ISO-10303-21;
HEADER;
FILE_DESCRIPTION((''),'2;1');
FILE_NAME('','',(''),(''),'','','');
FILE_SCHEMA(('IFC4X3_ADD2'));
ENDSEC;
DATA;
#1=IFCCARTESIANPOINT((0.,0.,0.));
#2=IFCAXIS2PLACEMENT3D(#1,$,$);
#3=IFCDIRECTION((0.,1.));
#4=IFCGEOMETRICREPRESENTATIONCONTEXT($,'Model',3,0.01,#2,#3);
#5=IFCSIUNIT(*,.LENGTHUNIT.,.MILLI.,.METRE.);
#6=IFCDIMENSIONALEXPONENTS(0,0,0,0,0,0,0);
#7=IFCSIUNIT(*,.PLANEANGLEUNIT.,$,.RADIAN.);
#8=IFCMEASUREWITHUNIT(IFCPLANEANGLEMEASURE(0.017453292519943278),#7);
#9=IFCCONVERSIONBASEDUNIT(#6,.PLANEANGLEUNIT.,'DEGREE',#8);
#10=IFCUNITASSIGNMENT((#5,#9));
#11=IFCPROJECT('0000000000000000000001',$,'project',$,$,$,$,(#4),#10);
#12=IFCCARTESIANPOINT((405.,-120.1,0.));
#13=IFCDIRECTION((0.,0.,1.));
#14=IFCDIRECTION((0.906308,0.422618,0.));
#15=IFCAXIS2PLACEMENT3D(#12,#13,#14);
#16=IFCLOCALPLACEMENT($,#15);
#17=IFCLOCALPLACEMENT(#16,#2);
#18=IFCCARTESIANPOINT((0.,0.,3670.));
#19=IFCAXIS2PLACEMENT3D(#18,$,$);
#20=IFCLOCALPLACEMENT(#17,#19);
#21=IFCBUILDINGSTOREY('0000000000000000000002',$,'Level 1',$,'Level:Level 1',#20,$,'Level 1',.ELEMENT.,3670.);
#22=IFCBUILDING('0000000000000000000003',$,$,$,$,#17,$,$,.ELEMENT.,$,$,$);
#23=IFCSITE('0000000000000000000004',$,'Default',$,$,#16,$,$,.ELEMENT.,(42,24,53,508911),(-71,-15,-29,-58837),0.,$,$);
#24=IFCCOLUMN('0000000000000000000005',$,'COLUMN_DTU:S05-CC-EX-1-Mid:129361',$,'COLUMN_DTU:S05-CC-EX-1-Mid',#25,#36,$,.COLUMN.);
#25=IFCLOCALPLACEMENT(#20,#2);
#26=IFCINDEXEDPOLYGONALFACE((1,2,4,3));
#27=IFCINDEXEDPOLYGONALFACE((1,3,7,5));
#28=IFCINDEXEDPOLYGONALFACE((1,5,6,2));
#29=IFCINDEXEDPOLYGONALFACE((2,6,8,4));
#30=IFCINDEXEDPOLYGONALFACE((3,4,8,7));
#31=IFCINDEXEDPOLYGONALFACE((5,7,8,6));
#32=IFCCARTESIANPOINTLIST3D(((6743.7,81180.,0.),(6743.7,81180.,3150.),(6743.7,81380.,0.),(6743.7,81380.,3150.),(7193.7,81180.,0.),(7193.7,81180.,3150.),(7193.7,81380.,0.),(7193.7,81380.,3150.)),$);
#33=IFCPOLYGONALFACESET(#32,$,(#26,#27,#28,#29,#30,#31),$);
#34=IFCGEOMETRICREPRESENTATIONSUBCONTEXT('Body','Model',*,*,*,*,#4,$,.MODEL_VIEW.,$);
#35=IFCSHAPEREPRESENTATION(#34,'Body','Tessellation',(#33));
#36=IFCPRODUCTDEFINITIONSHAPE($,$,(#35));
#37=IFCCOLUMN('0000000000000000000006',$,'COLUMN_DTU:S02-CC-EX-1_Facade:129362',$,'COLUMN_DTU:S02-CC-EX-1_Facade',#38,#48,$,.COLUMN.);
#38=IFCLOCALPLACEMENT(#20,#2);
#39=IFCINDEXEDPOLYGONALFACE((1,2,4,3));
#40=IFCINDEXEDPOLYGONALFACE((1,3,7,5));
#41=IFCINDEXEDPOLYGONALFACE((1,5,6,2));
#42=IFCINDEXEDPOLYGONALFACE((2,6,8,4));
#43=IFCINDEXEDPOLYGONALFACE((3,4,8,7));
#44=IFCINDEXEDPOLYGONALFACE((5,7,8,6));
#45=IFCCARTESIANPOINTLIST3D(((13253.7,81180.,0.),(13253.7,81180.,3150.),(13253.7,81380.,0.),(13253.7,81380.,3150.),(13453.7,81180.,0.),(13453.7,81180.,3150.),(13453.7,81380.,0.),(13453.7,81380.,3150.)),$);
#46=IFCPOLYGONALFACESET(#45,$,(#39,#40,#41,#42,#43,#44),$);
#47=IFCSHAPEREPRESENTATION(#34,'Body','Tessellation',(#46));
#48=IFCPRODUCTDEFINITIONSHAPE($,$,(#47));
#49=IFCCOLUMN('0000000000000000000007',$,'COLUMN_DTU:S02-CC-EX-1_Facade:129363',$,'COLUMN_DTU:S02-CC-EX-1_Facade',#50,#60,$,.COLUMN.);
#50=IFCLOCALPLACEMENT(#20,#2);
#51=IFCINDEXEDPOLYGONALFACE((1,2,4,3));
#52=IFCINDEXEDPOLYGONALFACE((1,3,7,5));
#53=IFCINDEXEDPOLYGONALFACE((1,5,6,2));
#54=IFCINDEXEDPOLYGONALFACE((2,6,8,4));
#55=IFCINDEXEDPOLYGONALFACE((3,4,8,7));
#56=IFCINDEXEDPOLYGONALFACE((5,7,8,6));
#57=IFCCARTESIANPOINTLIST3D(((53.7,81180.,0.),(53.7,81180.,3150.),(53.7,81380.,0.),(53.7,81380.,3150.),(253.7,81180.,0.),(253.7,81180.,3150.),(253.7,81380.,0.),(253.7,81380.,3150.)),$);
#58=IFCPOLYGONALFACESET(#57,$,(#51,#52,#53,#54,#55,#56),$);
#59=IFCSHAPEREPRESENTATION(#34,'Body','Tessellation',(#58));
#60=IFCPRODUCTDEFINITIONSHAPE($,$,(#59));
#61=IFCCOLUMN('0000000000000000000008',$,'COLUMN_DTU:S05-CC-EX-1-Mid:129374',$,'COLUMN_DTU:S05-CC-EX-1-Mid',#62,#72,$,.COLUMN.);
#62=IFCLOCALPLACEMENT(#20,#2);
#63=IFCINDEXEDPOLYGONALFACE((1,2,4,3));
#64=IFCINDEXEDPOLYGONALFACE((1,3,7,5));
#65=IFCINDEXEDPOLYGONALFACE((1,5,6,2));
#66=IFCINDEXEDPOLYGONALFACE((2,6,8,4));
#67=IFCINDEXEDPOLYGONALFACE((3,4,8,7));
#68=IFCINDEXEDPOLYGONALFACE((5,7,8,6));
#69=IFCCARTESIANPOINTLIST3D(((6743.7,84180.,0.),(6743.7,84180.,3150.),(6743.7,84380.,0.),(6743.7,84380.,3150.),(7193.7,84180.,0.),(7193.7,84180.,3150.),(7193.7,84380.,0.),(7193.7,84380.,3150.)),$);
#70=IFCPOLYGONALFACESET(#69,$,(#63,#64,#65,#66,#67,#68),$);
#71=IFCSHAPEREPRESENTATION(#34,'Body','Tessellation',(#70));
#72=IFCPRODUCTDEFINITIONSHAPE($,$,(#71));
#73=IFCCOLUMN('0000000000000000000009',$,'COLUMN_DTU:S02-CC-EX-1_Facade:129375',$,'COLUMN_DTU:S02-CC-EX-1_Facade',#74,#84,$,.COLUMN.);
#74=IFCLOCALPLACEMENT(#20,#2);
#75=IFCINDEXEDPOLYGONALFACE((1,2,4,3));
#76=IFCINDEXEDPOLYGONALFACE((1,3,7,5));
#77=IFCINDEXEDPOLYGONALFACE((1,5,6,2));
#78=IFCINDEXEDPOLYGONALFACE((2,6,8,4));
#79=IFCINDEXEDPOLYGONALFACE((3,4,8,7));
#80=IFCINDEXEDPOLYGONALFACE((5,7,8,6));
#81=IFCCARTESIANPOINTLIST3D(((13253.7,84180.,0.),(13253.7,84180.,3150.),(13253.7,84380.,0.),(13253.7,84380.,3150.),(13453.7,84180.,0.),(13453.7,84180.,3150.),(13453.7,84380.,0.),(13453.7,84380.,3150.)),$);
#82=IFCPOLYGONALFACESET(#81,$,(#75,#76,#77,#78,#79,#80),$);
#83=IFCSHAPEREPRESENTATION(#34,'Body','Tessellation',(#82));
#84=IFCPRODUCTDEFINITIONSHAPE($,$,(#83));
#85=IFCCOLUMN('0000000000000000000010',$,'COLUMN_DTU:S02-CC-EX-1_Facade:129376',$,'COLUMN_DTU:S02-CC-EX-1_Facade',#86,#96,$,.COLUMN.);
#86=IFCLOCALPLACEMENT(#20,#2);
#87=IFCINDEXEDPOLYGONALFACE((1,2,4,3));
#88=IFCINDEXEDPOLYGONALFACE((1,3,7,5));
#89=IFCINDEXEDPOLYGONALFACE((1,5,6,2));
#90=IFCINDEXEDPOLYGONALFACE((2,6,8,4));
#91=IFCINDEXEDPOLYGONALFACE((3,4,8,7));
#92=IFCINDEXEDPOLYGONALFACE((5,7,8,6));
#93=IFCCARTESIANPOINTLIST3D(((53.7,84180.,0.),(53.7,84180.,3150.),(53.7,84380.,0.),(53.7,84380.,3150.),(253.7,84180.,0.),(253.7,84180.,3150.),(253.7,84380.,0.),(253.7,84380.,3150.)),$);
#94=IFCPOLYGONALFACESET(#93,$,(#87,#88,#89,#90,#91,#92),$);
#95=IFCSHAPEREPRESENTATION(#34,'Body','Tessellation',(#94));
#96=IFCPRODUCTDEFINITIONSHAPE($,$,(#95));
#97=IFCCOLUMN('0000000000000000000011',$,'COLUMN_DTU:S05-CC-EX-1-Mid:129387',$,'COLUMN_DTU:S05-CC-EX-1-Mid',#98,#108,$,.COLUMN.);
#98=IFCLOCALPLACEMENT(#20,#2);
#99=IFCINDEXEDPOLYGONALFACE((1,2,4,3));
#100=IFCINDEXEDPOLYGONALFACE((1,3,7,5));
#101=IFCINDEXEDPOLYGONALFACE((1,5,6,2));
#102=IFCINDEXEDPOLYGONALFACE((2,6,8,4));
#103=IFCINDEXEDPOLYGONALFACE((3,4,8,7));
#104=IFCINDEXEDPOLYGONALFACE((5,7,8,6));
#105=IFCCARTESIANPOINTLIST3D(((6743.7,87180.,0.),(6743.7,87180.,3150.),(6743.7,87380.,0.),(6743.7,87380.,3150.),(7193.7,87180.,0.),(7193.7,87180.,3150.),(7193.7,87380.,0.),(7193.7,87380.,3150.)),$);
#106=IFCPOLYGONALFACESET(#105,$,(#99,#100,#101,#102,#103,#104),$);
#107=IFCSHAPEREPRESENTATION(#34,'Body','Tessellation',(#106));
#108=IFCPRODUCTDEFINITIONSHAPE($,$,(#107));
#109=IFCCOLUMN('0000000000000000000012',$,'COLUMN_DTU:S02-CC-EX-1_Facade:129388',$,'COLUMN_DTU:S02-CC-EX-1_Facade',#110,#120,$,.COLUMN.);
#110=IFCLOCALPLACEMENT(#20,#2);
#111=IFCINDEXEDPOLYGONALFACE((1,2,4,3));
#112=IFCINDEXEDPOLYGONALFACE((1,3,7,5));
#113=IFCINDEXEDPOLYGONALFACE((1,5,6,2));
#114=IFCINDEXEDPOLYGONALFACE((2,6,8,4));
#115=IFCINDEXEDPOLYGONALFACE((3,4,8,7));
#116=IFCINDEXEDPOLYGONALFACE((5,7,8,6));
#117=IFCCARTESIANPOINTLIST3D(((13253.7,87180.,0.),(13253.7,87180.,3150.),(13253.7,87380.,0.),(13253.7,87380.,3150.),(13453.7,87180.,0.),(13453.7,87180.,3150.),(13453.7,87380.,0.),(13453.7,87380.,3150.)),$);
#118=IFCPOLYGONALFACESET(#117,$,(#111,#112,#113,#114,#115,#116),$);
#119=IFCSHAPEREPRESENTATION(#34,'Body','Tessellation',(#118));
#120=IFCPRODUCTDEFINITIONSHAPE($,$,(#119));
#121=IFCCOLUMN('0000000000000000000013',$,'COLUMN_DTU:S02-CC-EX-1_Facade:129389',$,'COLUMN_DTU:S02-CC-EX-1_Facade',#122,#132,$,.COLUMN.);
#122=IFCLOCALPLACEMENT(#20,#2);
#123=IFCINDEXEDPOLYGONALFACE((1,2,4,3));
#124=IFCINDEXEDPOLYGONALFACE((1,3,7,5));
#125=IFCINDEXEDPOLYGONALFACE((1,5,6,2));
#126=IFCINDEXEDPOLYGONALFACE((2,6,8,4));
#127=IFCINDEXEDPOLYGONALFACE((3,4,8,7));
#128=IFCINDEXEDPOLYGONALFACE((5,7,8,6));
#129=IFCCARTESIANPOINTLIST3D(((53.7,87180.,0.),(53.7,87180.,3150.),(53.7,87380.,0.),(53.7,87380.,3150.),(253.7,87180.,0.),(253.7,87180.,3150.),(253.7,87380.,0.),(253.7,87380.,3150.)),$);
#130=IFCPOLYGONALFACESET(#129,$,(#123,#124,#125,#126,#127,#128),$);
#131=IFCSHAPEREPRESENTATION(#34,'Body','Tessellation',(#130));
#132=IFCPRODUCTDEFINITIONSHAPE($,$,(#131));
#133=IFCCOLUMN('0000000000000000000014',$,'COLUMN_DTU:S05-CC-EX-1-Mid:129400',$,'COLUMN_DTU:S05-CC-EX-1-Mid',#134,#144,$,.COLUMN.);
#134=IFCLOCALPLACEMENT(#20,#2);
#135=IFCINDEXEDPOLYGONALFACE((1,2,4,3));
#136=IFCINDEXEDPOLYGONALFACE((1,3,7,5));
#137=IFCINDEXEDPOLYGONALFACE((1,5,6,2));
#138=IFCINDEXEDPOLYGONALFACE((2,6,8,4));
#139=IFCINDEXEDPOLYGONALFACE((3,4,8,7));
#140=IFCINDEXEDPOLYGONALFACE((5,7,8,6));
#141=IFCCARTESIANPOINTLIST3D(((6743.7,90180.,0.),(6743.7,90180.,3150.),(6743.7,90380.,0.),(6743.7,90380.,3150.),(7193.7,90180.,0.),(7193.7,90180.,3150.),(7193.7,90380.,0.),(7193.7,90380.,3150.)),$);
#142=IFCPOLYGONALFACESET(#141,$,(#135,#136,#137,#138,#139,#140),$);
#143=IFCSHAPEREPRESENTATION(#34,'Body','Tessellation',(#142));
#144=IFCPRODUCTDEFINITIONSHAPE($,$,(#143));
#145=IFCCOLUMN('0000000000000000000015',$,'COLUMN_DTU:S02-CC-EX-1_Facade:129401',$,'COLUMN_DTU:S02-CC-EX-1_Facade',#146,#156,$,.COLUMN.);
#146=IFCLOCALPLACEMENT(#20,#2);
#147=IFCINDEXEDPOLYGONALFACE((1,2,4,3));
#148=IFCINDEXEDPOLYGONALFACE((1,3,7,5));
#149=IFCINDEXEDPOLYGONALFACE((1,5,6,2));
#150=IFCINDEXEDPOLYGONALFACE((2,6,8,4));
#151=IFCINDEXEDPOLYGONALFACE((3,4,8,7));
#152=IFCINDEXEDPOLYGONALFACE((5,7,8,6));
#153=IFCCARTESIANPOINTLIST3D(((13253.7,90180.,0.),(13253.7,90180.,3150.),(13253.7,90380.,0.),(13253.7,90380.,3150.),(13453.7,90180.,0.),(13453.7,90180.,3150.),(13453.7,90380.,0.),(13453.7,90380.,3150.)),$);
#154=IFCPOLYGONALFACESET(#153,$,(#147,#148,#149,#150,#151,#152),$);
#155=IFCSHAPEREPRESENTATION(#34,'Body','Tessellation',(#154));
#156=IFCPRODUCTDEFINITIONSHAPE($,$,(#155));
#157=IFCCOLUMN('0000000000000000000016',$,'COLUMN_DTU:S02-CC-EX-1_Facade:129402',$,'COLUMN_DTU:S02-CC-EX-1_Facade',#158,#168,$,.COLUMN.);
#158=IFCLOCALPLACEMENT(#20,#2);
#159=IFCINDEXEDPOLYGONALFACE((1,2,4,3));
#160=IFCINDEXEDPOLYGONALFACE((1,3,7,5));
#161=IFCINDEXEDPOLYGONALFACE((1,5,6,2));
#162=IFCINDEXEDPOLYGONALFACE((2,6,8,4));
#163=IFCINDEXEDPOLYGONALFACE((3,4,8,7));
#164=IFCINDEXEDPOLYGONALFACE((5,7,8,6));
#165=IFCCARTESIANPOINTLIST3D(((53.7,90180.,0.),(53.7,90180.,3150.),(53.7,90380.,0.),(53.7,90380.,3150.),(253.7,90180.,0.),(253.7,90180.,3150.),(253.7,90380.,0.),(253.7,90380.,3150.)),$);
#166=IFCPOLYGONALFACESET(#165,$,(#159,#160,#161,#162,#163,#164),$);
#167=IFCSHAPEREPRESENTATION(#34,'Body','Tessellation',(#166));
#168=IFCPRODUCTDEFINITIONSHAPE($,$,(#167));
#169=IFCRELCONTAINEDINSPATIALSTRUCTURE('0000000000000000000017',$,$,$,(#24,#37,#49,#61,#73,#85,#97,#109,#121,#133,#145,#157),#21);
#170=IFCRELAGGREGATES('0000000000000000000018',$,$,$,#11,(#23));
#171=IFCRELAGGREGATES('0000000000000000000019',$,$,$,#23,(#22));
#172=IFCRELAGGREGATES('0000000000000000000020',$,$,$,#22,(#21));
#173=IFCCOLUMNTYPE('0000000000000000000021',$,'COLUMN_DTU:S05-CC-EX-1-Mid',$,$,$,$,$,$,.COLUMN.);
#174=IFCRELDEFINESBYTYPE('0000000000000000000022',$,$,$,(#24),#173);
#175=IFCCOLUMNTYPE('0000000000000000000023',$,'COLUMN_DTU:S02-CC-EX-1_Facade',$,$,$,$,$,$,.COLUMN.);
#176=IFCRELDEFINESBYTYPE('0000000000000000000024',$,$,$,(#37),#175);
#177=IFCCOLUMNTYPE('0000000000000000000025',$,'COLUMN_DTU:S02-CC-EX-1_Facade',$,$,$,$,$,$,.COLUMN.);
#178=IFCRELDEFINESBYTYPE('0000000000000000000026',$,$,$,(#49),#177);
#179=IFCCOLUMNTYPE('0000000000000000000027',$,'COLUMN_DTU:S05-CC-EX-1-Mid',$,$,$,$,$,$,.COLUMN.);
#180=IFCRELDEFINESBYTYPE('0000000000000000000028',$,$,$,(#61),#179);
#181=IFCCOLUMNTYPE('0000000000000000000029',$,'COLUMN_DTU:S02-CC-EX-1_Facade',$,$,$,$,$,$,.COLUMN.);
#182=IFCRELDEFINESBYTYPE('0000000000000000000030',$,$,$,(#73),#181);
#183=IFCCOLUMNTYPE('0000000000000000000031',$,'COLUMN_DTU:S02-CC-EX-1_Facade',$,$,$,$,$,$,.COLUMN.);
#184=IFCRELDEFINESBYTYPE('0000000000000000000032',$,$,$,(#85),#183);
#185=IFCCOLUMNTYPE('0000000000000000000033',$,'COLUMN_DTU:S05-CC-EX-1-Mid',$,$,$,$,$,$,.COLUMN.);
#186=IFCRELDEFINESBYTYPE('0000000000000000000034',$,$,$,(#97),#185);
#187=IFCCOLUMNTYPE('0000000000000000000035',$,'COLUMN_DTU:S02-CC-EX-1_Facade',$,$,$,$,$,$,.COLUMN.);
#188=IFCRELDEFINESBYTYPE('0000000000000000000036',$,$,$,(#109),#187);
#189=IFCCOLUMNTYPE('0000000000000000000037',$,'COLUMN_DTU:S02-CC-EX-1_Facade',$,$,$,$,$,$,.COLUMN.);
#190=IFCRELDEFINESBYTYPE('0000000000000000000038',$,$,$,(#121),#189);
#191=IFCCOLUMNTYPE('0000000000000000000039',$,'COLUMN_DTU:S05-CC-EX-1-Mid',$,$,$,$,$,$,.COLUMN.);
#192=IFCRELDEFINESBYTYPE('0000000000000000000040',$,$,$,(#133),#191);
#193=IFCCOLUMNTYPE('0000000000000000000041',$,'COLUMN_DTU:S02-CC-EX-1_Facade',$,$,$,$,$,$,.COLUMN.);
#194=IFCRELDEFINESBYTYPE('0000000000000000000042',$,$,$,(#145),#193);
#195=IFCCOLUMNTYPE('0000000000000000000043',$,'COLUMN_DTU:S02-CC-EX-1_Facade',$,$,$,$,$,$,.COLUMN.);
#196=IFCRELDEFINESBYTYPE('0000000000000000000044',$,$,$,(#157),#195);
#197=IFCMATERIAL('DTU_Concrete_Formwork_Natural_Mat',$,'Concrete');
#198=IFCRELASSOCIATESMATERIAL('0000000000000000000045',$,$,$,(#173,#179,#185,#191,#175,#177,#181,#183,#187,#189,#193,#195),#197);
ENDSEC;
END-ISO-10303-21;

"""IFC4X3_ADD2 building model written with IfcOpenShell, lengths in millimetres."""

from ifc_helpers import new_model, entity, si_unit, converted_unit, direction, frame, frame_2d, origin, origin_2d_with_axis, place, context, subcontext, project, spatial, rectangle, extrude, source, transform, mapped, material, material_profile, profile_set, type_object, type_shapes, element, save


model = new_model("IFC4X3_ADD2")

# Units and contexts
model_context = context("Model", 3, precision=0.01, world=origin(), true_north=direction((0.0, 1.0)))
body_context = subcontext(model_context, "Body", "Model", "MODEL_VIEW")
ifc_project = project(units=[si_unit("LENGTHUNIT", "METRE", prefix="MILLI"), converted_unit("PLANEANGLEUNIT", "DEGREE", entity("IfcPlaneAngleMeasure", 0.017453292519943278), si_unit("PLANEANGLEUNIT", "RADIAN"), dimensions=[0, 0, 0, 0, 0, 0, 0])], contexts=[model_context])

# Site, building, storey
site_placement = place(None, frame((405.0, -120.1, 0.0), z_axis=(0.0, 0.0, 1.0), x_axis=(0.906308, 0.422618, 0.0)))
site = spatial("IfcSite", under=ifc_project, at=site_placement, Name="Default", CompositionType="ELEMENT", RefLatitude=(42, 24, 53, 508911), RefLongitude=(-71, -15, -29, -58837), RefElevation=0.0)
building_placement = place(site_placement, origin())
building = spatial("IfcBuilding", under=site, at=building_placement, CompositionType="ELEMENT")
storey_placement = place(building_placement, frame((0.0, 0.0, 3670.0)))
storey = spatial("IfcBuildingStorey", under=building, at=storey_placement, Name="Level 1", ObjectType="Level:Level 1", LongName="Level 1", CompositionType="ELEMENT", Elevation=3670.0)

# Columns
ifc_material = material(Name="DTU_Concrete_Formwork_Natural_Mat", Category="Concrete")
ifc_material_profile_1 = material_profile(ifc_material, rectangle(XDim=200.0, YDim=450.0, at=origin_2d_with_axis()), Name="S05-CC-EX-1-Mid")
ifc_profile_set_1 = profile_set([ifc_material_profile_1], Name="S05-CC-EX-1-Mid")
ifc_material_profile_2 = material_profile(ifc_material, rectangle(XDim=200.0, YDim=200.0, at=frame_2d((0.0, 0.0), x_axis=(1.0, 0.0))), Name="S02-CC-EX-1_Facade")
ifc_profile_set_2 = profile_set([ifc_material_profile_2], Name="S02-CC-EX-1_Facade")
column_type_1 = type_object("IfcColumnType", Name="COLUMN_DTU:S05-CC-EX-1-Mid", PredefinedType="COLUMN", material=ifc_profile_set_1)
shared_shape_1 = source(origin(), body_context, "Body", "SweptSolid", [
    extrude(rectangle(XDim=200.0, YDim=450.0, at=frame_2d((0.0, 0.0), x_axis=(1.0, 0.0))), frame((6968.7, 81280.0, 3670.0), z_axis=(0.0, 0.0, 1.0), x_axis=(0.0, 1.0, 0.0)), (0.0, 0.0, 1.0), 3150.0),
])
type_shapes(column_type_1, [shared_shape_1])
column_1_placement = place(storey_placement, frame((0.0, 0.0, -3670.0)))
element("IfcColumn", 1, at=column_1_placement, inside=storey, type_object=column_type_1, Name="COLUMN_DTU:S05-CC-EX-1-Mid:129361", ObjectType="COLUMN_DTU:S05-CC-EX-1-Mid", PredefinedType="COLUMN", context=body_context, shape_type="MappedRepresentation", body=[
    mapped(shared_shape_1, transform((0.0, 0.0, 0.0), scale=1.0)),
])
column_type_2 = type_object("IfcColumnType", Name="COLUMN_DTU:S02-CC-EX-1_Facade", PredefinedType="COLUMN", material=ifc_profile_set_2)
shared_shape_2 = source(origin(), body_context, "Body", "SweptSolid", [
    extrude(rectangle(XDim=200.0, YDim=200.0, at=frame_2d((0.0, 0.0), x_axis=(1.0, 0.0))), frame((13353.7, 81280.0, 3670.0), z_axis=(0.0, 0.0, 1.0), x_axis=(0.0, -1.0, 0.0)), (0.0, 0.0, 1.0), 3150.0),
])
type_shapes(column_type_2, [shared_shape_2])
column_2_placement = place(storey_placement, frame((0.0, 0.0, -3670.0)))
element("IfcColumn", 2, at=column_2_placement, inside=storey, type_object=column_type_2, Name="COLUMN_DTU:S02-CC-EX-1_Facade:129362", ObjectType="COLUMN_DTU:S02-CC-EX-1_Facade", PredefinedType="COLUMN", context=body_context, shape_type="MappedRepresentation", body=[
    mapped(shared_shape_2, transform((0.0, 0.0, 0.0), scale=1.0)),
])
column_type_3 = type_object("IfcColumnType", Name="COLUMN_DTU:S02-CC-EX-1_Facade", PredefinedType="COLUMN", material=ifc_profile_set_2)
shared_shape_3 = source(origin(), body_context, "Body", "SweptSolid", [
    extrude(rectangle(XDim=200.0, YDim=200.0, at=frame_2d((0.0, 0.0), x_axis=(1.0, 0.0))), frame((153.7, 81280.0, 3670.0), z_axis=(0.0, 0.0, 1.0), x_axis=(0.0, -1.0, 0.0)), (0.0, 0.0, 1.0), 3150.0),
])
type_shapes(column_type_3, [shared_shape_3])
column_3_placement = place(storey_placement, frame((0.0, 0.0, -3670.0)))
element("IfcColumn", 3, at=column_3_placement, inside=storey, type_object=column_type_3, Name="COLUMN_DTU:S02-CC-EX-1_Facade:129363", ObjectType="COLUMN_DTU:S02-CC-EX-1_Facade", PredefinedType="COLUMN", context=body_context, shape_type="MappedRepresentation", body=[
    mapped(shared_shape_3, transform((0.0, 0.0, 0.0), scale=1.0)),
])
column_type_4 = type_object("IfcColumnType", Name="COLUMN_DTU:S05-CC-EX-1-Mid", PredefinedType="COLUMN", material=ifc_profile_set_1)
shared_shape_4 = source(origin(), body_context, "Body", "SweptSolid", [
    extrude(rectangle(XDim=200.0, YDim=450.0, at=frame_2d((0.0, 0.0), x_axis=(1.0, 0.0))), frame((6968.7, 84280.0, 3670.0), z_axis=(0.0, 0.0, 1.0), x_axis=(0.0, 1.0, 0.0)), (0.0, 0.0, 1.0), 3150.0),
])
type_shapes(column_type_4, [shared_shape_4])
column_4_placement = place(storey_placement, frame((0.0, 0.0, -3670.0)))
element("IfcColumn", 4, at=column_4_placement, inside=storey, type_object=column_type_4, Name="COLUMN_DTU:S05-CC-EX-1-Mid:129374", ObjectType="COLUMN_DTU:S05-CC-EX-1-Mid", PredefinedType="COLUMN", context=body_context, shape_type="MappedRepresentation", body=[
    mapped(shared_shape_4, transform((0.0, 0.0, 0.0), scale=1.0)),
])
column_type_5 = type_object("IfcColumnType", Name="COLUMN_DTU:S02-CC-EX-1_Facade", PredefinedType="COLUMN", material=ifc_profile_set_2)
shared_shape_5 = source(origin(), body_context, "Body", "SweptSolid", [
    extrude(rectangle(XDim=200.0, YDim=200.0, at=frame_2d((0.0, 0.0), x_axis=(1.0, 0.0))), frame((13353.7, 84280.0, 3670.0), z_axis=(0.0, 0.0, 1.0), x_axis=(0.0, -1.0, 0.0)), (0.0, 0.0, 1.0), 3150.0),
])
type_shapes(column_type_5, [shared_shape_5])
column_5_placement = place(storey_placement, frame((0.0, 0.0, -3670.0)))
element("IfcColumn", 5, at=column_5_placement, inside=storey, type_object=column_type_5, Name="COLUMN_DTU:S02-CC-EX-1_Facade:129375", ObjectType="COLUMN_DTU:S02-CC-EX-1_Facade", PredefinedType="COLUMN", context=body_context, shape_type="MappedRepresentation", body=[
    mapped(shared_shape_5, transform((0.0, 0.0, 0.0), scale=1.0)),
])
column_type_6 = type_object("IfcColumnType", Name="COLUMN_DTU:S02-CC-EX-1_Facade", PredefinedType="COLUMN", material=ifc_profile_set_2)
shared_shape_6 = source(origin(), body_context, "Body", "SweptSolid", [
    extrude(rectangle(XDim=200.0, YDim=200.0, at=frame_2d((0.0, 0.0), x_axis=(1.0, 0.0))), frame((153.7, 84280.0, 3670.0), z_axis=(0.0, 0.0, 1.0), x_axis=(0.0, -1.0, 0.0)), (0.0, 0.0, 1.0), 3150.0),
])
type_shapes(column_type_6, [shared_shape_6])
column_6_placement = place(storey_placement, frame((0.0, 0.0, -3670.0)))
element("IfcColumn", 6, at=column_6_placement, inside=storey, type_object=column_type_6, Name="COLUMN_DTU:S02-CC-EX-1_Facade:129376", ObjectType="COLUMN_DTU:S02-CC-EX-1_Facade", PredefinedType="COLUMN", context=body_context, shape_type="MappedRepresentation", body=[
    mapped(shared_shape_6, transform((0.0, 0.0, 0.0), scale=1.0)),
])
column_type_7 = type_object("IfcColumnType", Name="COLUMN_DTU:S05-CC-EX-1-Mid", PredefinedType="COLUMN", material=ifc_profile_set_1)
shared_shape_7 = source(origin(), body_context, "Body", "SweptSolid", [
    extrude(rectangle(XDim=200.0, YDim=450.0, at=frame_2d((0.0, 0.0), x_axis=(1.0, 0.0))), frame((6968.7, 87280.0, 3670.0), z_axis=(0.0, 0.0, 1.0), x_axis=(0.0, 1.0, 0.0)), (0.0, 0.0, 1.0), 3150.0),
])
type_shapes(column_type_7, [shared_shape_7])
column_7_placement = place(storey_placement, frame((0.0, 0.0, -3670.0)))
element("IfcColumn", 7, at=column_7_placement, inside=storey, type_object=column_type_7, Name="COLUMN_DTU:S05-CC-EX-1-Mid:129387", ObjectType="COLUMN_DTU:S05-CC-EX-1-Mid", PredefinedType="COLUMN", context=body_context, shape_type="MappedRepresentation", body=[
    mapped(shared_shape_7, transform((0.0, 0.0, 0.0), scale=1.0)),
])
column_type_8 = type_object("IfcColumnType", Name="COLUMN_DTU:S02-CC-EX-1_Facade", PredefinedType="COLUMN", material=ifc_profile_set_2)
shared_shape_8 = source(origin(), body_context, "Body", "SweptSolid", [
    extrude(rectangle(XDim=200.0, YDim=200.0, at=frame_2d((0.0, 0.0), x_axis=(1.0, 0.0))), frame((13353.7, 87280.0, 3670.0), z_axis=(0.0, 0.0, 1.0), x_axis=(0.0, -1.0, 0.0)), (0.0, 0.0, 1.0), 3150.0),
])
type_shapes(column_type_8, [shared_shape_8])
column_8_placement = place(storey_placement, frame((0.0, 0.0, -3670.0)))
element("IfcColumn", 8, at=column_8_placement, inside=storey, type_object=column_type_8, Name="COLUMN_DTU:S02-CC-EX-1_Facade:129388", ObjectType="COLUMN_DTU:S02-CC-EX-1_Facade", PredefinedType="COLUMN", context=body_context, shape_type="MappedRepresentation", body=[
    mapped(shared_shape_8, transform((0.0, 0.0, 0.0), scale=1.0)),
])
column_type_9 = type_object("IfcColumnType", Name="COLUMN_DTU:S02-CC-EX-1_Facade", PredefinedType="COLUMN", material=ifc_profile_set_2)
shared_shape_9 = source(origin(), body_context, "Body", "SweptSolid", [
    extrude(rectangle(XDim=200.0, YDim=200.0, at=frame_2d((0.0, 0.0), x_axis=(1.0, 0.0))), frame((153.7, 87280.0, 3670.0), z_axis=(0.0, 0.0, 1.0), x_axis=(0.0, -1.0, 0.0)), (0.0, 0.0, 1.0), 3150.0),
])
type_shapes(column_type_9, [shared_shape_9])
column_9_placement = place(storey_placement, frame((0.0, 0.0, -3670.0)))
element("IfcColumn", 9, at=column_9_placement, inside=storey, type_object=column_type_9, Name="COLUMN_DTU:S02-CC-EX-1_Facade:129389", ObjectType="COLUMN_DTU:S02-CC-EX-1_Facade", PredefinedType="COLUMN", context=body_context, shape_type="MappedRepresentation", body=[
    mapped(shared_shape_9, transform((0.0, 0.0, 0.0), scale=1.0)),
])
column_type_10 = type_object("IfcColumnType", Name="COLUMN_DTU:S05-CC-EX-1-Mid", PredefinedType="COLUMN", material=ifc_profile_set_1)
shared_shape_10 = source(origin(), body_context, "Body", "SweptSolid", [
    extrude(rectangle(XDim=200.0, YDim=450.0, at=frame_2d((0.0, 0.0), x_axis=(1.0, 0.0))), frame((6968.7, 90280.0, 3670.0), z_axis=(0.0, 0.0, 1.0), x_axis=(0.0, 1.0, 0.0)), (0.0, 0.0, 1.0), 3150.0),
])
type_shapes(column_type_10, [shared_shape_10])
column_10_placement = place(storey_placement, frame((0.0, 0.0, -3670.0)))
element("IfcColumn", 10, at=column_10_placement, inside=storey, type_object=column_type_10, Name="COLUMN_DTU:S05-CC-EX-1-Mid:129400", ObjectType="COLUMN_DTU:S05-CC-EX-1-Mid", PredefinedType="COLUMN", context=body_context, shape_type="MappedRepresentation", body=[
    mapped(shared_shape_10, transform((0.0, 0.0, 0.0), scale=1.0)),
])
column_type_11 = type_object("IfcColumnType", Name="COLUMN_DTU:S02-CC-EX-1_Facade", PredefinedType="COLUMN", material=ifc_profile_set_2)
shared_shape_11 = source(origin(), body_context, "Body", "SweptSolid", [
    extrude(rectangle(XDim=200.0, YDim=200.0, at=frame_2d((0.0, 0.0), x_axis=(1.0, 0.0))), frame((13353.7, 90280.0, 3670.0), z_axis=(0.0, 0.0, 1.0), x_axis=(0.0, -1.0, 0.0)), (0.0, 0.0, 1.0), 3150.0),
])
type_shapes(column_type_11, [shared_shape_11])
column_11_placement = place(storey_placement, frame((0.0, 0.0, -3670.0)))
element("IfcColumn", 11, at=column_11_placement, inside=storey, type_object=column_type_11, Name="COLUMN_DTU:S02-CC-EX-1_Facade:129401", ObjectType="COLUMN_DTU:S02-CC-EX-1_Facade", PredefinedType="COLUMN", context=body_context, shape_type="MappedRepresentation", body=[
    mapped(shared_shape_11, transform((0.0, 0.0, 0.0), scale=1.0)),
])
column_type_12 = type_object("IfcColumnType", Name="COLUMN_DTU:S02-CC-EX-1_Facade", PredefinedType="COLUMN", material=ifc_profile_set_2)
shared_shape_12 = source(origin(), body_context, "Body", "SweptSolid", [
    extrude(rectangle(XDim=200.0, YDim=200.0, at=frame_2d((0.0, 0.0), x_axis=(1.0, 0.0))), frame((153.7, 90280.0, 3670.0), z_axis=(0.0, 0.0, 1.0), x_axis=(0.0, -1.0, 0.0)), (0.0, 0.0, 1.0), 3150.0),
])
type_shapes(column_type_12, [shared_shape_12])
column_12_placement = place(storey_placement, frame((0.0, 0.0, -3670.0)))
element("IfcColumn", 12, at=column_12_placement, inside=storey, type_object=column_type_12, Name="COLUMN_DTU:S02-CC-EX-1_Facade:129402", ObjectType="COLUMN_DTU:S02-CC-EX-1_Facade", PredefinedType="COLUMN", context=body_context, shape_type="MappedRepresentation", body=[
    mapped(shared_shape_12, transform((0.0, 0.0, 0.0), scale=1.0)),
])

save(model, "model.ifc")
